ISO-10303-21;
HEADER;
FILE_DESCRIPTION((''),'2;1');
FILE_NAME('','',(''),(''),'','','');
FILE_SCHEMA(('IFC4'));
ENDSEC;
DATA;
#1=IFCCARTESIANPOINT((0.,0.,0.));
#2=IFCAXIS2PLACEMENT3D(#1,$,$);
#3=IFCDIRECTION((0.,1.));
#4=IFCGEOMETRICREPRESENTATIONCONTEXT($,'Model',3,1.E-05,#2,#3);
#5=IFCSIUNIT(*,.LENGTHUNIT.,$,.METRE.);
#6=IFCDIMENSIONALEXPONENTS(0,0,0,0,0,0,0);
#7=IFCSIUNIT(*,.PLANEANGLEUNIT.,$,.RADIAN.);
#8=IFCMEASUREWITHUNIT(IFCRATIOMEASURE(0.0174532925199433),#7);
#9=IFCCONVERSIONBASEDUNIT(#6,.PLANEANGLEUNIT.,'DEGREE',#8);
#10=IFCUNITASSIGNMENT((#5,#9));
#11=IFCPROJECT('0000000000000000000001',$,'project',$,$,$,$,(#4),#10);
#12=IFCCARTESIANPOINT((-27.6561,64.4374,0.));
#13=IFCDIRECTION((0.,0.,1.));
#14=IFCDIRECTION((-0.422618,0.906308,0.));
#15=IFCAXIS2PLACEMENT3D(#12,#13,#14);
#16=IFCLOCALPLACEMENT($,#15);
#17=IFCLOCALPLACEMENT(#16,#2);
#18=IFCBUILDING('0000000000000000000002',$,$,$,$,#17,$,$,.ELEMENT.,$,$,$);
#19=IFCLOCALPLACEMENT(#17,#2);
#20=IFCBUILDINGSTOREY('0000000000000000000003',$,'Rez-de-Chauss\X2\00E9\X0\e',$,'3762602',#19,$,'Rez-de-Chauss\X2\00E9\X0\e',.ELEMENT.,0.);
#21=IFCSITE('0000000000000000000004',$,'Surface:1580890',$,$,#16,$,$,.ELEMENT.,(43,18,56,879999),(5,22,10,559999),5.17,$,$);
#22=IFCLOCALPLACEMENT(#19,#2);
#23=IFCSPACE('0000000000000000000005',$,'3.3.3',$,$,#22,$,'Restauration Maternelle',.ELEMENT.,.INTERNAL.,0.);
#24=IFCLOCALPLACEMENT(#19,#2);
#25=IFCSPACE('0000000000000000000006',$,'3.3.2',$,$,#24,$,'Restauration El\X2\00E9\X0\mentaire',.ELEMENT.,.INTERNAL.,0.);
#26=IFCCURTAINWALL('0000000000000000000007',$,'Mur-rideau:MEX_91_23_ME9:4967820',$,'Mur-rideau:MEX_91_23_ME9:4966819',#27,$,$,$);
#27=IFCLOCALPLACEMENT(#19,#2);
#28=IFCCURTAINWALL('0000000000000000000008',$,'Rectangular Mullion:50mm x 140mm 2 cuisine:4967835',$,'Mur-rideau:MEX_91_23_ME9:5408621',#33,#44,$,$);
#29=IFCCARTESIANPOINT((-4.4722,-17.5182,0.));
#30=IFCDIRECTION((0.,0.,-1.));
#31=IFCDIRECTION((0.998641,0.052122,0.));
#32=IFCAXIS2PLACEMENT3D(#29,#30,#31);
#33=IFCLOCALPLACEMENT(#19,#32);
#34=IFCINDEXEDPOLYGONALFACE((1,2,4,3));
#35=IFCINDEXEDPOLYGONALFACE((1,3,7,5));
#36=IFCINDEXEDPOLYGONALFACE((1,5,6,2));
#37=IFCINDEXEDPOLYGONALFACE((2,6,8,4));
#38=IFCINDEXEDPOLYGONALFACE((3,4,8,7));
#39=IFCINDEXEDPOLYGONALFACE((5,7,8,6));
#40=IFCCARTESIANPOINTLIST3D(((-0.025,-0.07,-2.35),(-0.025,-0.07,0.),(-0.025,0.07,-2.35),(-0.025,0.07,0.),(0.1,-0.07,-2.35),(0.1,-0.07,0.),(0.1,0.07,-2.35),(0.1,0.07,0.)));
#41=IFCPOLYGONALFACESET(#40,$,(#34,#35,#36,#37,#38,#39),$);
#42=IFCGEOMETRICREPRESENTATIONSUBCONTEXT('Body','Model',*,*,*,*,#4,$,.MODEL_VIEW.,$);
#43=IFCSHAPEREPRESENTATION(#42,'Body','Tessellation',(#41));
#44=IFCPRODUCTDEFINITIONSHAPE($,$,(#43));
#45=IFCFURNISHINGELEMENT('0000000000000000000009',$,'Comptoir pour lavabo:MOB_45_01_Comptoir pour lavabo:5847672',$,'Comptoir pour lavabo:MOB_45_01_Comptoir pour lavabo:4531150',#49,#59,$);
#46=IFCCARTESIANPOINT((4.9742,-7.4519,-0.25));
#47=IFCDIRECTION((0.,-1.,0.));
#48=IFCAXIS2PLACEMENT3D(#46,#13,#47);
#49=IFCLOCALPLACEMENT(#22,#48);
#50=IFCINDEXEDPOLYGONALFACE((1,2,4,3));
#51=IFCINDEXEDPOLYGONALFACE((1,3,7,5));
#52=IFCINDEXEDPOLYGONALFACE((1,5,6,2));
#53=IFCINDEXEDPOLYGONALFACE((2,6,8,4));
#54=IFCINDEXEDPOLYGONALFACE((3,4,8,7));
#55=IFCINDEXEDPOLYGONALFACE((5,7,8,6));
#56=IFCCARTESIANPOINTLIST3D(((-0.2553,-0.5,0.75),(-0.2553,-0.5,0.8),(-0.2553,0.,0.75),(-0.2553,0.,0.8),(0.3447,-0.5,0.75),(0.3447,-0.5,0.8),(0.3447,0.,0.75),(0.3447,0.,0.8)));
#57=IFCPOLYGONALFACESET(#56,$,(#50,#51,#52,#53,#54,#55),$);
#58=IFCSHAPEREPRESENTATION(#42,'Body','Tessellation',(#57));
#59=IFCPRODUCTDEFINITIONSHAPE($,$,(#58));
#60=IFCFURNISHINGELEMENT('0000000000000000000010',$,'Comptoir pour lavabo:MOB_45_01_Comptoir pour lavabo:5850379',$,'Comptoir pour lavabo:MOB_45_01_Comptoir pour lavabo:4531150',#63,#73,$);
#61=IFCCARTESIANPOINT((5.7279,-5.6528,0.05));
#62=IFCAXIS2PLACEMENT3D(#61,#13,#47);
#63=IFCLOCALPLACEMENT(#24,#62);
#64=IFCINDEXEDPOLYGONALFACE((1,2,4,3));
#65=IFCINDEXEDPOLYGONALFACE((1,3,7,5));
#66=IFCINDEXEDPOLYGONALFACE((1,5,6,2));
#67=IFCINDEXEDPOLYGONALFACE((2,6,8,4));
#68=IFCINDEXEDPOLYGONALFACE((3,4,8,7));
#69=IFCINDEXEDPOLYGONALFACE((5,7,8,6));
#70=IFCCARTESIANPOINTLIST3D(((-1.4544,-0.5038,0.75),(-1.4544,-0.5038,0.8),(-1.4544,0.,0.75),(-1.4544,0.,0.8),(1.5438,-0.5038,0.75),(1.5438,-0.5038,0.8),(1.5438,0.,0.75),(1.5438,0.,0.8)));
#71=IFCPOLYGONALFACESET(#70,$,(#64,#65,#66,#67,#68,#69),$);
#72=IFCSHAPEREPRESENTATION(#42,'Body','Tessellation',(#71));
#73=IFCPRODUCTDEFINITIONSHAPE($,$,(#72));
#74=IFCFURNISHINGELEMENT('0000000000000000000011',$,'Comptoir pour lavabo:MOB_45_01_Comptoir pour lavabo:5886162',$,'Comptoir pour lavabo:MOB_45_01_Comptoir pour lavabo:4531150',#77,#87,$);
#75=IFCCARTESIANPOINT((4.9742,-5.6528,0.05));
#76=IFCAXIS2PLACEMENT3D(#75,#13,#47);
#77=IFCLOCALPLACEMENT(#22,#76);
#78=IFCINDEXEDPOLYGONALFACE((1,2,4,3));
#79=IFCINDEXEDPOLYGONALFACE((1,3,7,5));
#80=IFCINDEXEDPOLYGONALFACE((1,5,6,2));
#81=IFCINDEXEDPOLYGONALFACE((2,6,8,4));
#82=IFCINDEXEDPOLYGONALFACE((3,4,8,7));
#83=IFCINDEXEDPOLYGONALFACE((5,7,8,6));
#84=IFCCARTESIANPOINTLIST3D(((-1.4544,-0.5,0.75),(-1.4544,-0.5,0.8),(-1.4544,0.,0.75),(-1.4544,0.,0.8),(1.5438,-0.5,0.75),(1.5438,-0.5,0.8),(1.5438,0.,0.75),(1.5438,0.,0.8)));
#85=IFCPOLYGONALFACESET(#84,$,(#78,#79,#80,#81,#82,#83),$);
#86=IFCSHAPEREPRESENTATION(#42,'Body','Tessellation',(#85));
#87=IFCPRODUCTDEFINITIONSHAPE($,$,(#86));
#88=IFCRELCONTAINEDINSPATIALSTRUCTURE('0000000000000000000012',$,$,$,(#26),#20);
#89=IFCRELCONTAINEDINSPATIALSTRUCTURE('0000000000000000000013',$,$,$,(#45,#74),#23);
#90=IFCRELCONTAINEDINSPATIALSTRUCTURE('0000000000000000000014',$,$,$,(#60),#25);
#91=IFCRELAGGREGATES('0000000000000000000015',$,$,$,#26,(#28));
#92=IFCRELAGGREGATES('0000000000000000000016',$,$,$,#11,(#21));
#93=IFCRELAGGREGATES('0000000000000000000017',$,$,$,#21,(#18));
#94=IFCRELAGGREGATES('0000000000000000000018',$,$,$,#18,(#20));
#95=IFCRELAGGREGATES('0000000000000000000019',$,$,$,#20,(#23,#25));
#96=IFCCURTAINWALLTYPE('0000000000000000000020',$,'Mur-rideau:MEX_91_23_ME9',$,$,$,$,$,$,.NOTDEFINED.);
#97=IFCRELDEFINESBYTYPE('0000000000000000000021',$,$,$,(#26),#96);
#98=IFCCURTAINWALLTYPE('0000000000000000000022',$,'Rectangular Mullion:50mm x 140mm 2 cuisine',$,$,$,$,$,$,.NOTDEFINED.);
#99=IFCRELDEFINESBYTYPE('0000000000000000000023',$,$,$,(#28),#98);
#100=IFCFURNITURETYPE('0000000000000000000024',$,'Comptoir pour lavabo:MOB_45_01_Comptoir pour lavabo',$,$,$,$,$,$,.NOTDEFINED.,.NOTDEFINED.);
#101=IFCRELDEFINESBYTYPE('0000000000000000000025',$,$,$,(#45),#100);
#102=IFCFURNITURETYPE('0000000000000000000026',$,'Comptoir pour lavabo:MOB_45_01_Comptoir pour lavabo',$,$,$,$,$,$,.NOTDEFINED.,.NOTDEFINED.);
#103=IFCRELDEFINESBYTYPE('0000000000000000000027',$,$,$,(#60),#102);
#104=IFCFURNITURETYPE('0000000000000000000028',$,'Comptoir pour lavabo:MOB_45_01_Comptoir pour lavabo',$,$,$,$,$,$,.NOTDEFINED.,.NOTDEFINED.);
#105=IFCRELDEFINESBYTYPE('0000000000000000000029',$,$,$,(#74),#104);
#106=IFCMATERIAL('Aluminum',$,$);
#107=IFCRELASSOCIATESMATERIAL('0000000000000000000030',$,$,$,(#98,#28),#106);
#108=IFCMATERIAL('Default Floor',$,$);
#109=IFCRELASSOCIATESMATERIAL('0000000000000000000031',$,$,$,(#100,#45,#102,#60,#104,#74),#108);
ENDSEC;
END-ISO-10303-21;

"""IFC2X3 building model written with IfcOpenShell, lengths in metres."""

from ifc_helpers import new_model, entity, si_unit, converted_unit, direction, frame, origin, origin_2d_with_axis, place, context, subcontext, project, spatial, rectangle, extrude, source, transform, mapped, material, type_object, type_shapes, element, aggregate, save


model = new_model("IFC2X3")

# Units and contexts
model_context = context("Model", 3, precision=1e-05, world=origin(), true_north=direction((0.0, 1.0)))
body_context = subcontext(model_context, "Body", "Model", "MODEL_VIEW")
ifc_project = project(units=[si_unit("LENGTHUNIT", "METRE"), converted_unit("PLANEANGLEUNIT", "DEGREE", entity("IfcRatioMeasure", 0.0174532925199433), si_unit("PLANEANGLEUNIT", "RADIAN"), dimensions=[0, 0, 0, 0, 0, 0, 0])], contexts=[model_context])

# Site, building, storey
site_placement = place(None, frame((-27.6561, 64.4374, 0.0), z_axis=(0.0, 0.0, 1.0), x_axis=(-0.422618, 0.906308, 0.0)))
site = spatial("IfcSite", under=ifc_project, at=site_placement, Name="Surface:1580890", CompositionType="ELEMENT", RefLatitude=(43, 18, 56, 879999), RefLongitude=(5, 22, 10, 559999), RefElevation=5.17)
building_placement = place(site_placement, origin())
building = spatial("IfcBuilding", under=site, at=building_placement, CompositionType="ELEMENT")
storey_placement = place(building_placement, origin())
storey = spatial("IfcBuildingStorey", under=building, at=storey_placement, Name="Rez-de-Chaussée", ObjectType="3762602", LongName="Rez-de-Chaussée", CompositionType="ELEMENT", Elevation=0.0)

# Curtain walls
curtain_wall_type_1 = type_object("IfcCurtainWallType", Name="Mur-rideau:MEX_91_23_ME9", PredefinedType="NOTDEFINED")
curtain_wall_1_placement = place(storey_placement, origin())
curtain_wall_1 = element("IfcCurtainWall", 1, at=curtain_wall_1_placement, inside=storey, type_object=curtain_wall_type_1, Name="Mur-rideau:MEX_91_23_ME9:4967820", ObjectType="Mur-rideau:MEX_91_23_ME9:4966819")
ifc_material_1 = material(Name="Aluminum")
curtain_wall_type_2 = type_object("IfcCurtainWallType", Name="Rectangular Mullion:50mm x 140mm 2 cuisine", PredefinedType="NOTDEFINED", material=ifc_material_1)
shared_shape_1 = source(origin(), body_context, "Body", "SweptSolid", [
    extrude(rectangle(XDim=0.125, YDim=0.14, at=origin_2d_with_axis()), frame((0.0375, 0.0, -2.35), z_axis=(0.0, 0.0, 1.0), x_axis=(-1.0, 0.0, 0.0)), (0.0, 0.0, 1.0), 2.35),
])
type_shapes(curtain_wall_type_2, [shared_shape_1])
curtain_wall_2_placement = place(storey_placement, frame((-4.4722, -17.5182, 0.0), z_axis=(0.0, 0.0, -1.0), x_axis=(0.998641, 0.052122, 0.0)))
curtain_wall_2 = element("IfcCurtainWall", 2, at=curtain_wall_2_placement, type_object=curtain_wall_type_2, material=ifc_material_1, Name="Rectangular Mullion:50mm x 140mm 2 cuisine:4967835", ObjectType="Mur-rideau:MEX_91_23_ME9:5408621", context=body_context, shape_type="MappedRepresentation", body=[
    mapped(shared_shape_1, transform((0.0, 0.0, 0.0), scale=1.0)),
])
aggregate(curtain_wall_1, [curtain_wall_2])

# Shared definitions
space_1_placement = place(storey_placement, origin())
space_1 = spatial("IfcSpace", under=storey, at=space_1_placement, Name="3.3.3", LongName="Restauration Maternelle", CompositionType="ELEMENT", InteriorOrExteriorSpace="INTERNAL", ElevationWithFlooring=0.0)

# Furnishing element
ifc_material_2 = material(Name="Default Floor")
furniture_type_1 = type_object("IfcFurnitureType", Name="Comptoir pour lavabo:MOB_45_01_Comptoir pour lavabo", material=ifc_material_2)
shared_shape_2 = source(origin(), body_context, "Body", "SweptSolid", [
    extrude(rectangle(XDim=0.6, YDim=0.5, at=origin_2d_with_axis()), frame((0.0447, -0.25, 0.75), z_axis=(0.0, 0.0, 1.0), x_axis=(-1.0, 0.0, 0.0)), (0.0, 0.0, 1.0), 0.05),
])
type_shapes(furniture_type_1, [shared_shape_2])
furnishing_1_placement = place(space_1_placement, frame((4.9742, -7.4519, -0.25), z_axis=(0.0, 0.0, 1.0), x_axis=(0.0, -1.0, 0.0)))
element("IfcFurnishingElement", 3, at=furnishing_1_placement, inside=space_1, type_object=furniture_type_1, material=ifc_material_2, Name="Comptoir pour lavabo:MOB_45_01_Comptoir pour lavabo:5847672", ObjectType="Comptoir pour lavabo:MOB_45_01_Comptoir pour lavabo:4531150", context=body_context, shape_type="MappedRepresentation", body=[
    mapped(shared_shape_2, transform((0.0, 0.0, 0.0), scale=1.0)),
])

# Shared definitions
space_2_placement = place(storey_placement, origin())
space_2 = spatial("IfcSpace", under=storey, at=space_2_placement, Name="3.3.2", LongName="Restauration Elémentaire", CompositionType="ELEMENT", InteriorOrExteriorSpace="INTERNAL", ElevationWithFlooring=0.0)

# Furnishing elements
furniture_type_2 = type_object("IfcFurnitureType", Name="Comptoir pour lavabo:MOB_45_01_Comptoir pour lavabo", material=ifc_material_2)
shared_shape_3 = source(origin(), body_context, "Body", "SweptSolid", [
    extrude(rectangle(XDim=2.9982, YDim=0.5038, at=origin_2d_with_axis()), frame((0.0447, -0.2519, 0.75), z_axis=(0.0, 0.0, 1.0), x_axis=(-1.0, 0.0, 0.0)), (0.0, 0.0, 1.0), 0.05),
])
type_shapes(furniture_type_2, [shared_shape_3])
furnishing_2_placement = place(space_2_placement, frame((5.7279, -5.6528, 0.05), z_axis=(0.0, 0.0, 1.0), x_axis=(0.0, -1.0, 0.0)))
element("IfcFurnishingElement", 4, at=furnishing_2_placement, inside=space_2, type_object=furniture_type_2, material=ifc_material_2, Name="Comptoir pour lavabo:MOB_45_01_Comptoir pour lavabo:5850379", ObjectType="Comptoir pour lavabo:MOB_45_01_Comptoir pour lavabo:4531150", context=body_context, shape_type="MappedRepresentation", body=[
    mapped(shared_shape_3, transform((0.0, 0.0, 0.0), scale=1.0)),
])
furniture_type_3 = type_object("IfcFurnitureType", Name="Comptoir pour lavabo:MOB_45_01_Comptoir pour lavabo", material=ifc_material_2)
shared_shape_4 = source(origin(), body_context, "Body", "SweptSolid", [
    extrude(rectangle(XDim=2.9982, YDim=0.5, at=origin_2d_with_axis()), frame((0.0447, -0.25, 0.75), z_axis=(0.0, 0.0, 1.0), x_axis=(-1.0, 0.0, 0.0)), (0.0, 0.0, 1.0), 0.05),
])
type_shapes(furniture_type_3, [shared_shape_4])
furnishing_3_placement = place(space_1_placement, frame((4.9742, -5.6528, 0.05), z_axis=(0.0, 0.0, 1.0), x_axis=(0.0, -1.0, 0.0)))
element("IfcFurnishingElement", 5, at=furnishing_3_placement, inside=space_1, type_object=furniture_type_3, material=ifc_material_2, Name="Comptoir pour lavabo:MOB_45_01_Comptoir pour lavabo:5886162", ObjectType="Comptoir pour lavabo:MOB_45_01_Comptoir pour lavabo:4531150", context=body_context, shape_type="MappedRepresentation", body=[
    mapped(shared_shape_4, transform((0.0, 0.0, 0.0), scale=1.0)),
])

save(model, "model.ifc")
